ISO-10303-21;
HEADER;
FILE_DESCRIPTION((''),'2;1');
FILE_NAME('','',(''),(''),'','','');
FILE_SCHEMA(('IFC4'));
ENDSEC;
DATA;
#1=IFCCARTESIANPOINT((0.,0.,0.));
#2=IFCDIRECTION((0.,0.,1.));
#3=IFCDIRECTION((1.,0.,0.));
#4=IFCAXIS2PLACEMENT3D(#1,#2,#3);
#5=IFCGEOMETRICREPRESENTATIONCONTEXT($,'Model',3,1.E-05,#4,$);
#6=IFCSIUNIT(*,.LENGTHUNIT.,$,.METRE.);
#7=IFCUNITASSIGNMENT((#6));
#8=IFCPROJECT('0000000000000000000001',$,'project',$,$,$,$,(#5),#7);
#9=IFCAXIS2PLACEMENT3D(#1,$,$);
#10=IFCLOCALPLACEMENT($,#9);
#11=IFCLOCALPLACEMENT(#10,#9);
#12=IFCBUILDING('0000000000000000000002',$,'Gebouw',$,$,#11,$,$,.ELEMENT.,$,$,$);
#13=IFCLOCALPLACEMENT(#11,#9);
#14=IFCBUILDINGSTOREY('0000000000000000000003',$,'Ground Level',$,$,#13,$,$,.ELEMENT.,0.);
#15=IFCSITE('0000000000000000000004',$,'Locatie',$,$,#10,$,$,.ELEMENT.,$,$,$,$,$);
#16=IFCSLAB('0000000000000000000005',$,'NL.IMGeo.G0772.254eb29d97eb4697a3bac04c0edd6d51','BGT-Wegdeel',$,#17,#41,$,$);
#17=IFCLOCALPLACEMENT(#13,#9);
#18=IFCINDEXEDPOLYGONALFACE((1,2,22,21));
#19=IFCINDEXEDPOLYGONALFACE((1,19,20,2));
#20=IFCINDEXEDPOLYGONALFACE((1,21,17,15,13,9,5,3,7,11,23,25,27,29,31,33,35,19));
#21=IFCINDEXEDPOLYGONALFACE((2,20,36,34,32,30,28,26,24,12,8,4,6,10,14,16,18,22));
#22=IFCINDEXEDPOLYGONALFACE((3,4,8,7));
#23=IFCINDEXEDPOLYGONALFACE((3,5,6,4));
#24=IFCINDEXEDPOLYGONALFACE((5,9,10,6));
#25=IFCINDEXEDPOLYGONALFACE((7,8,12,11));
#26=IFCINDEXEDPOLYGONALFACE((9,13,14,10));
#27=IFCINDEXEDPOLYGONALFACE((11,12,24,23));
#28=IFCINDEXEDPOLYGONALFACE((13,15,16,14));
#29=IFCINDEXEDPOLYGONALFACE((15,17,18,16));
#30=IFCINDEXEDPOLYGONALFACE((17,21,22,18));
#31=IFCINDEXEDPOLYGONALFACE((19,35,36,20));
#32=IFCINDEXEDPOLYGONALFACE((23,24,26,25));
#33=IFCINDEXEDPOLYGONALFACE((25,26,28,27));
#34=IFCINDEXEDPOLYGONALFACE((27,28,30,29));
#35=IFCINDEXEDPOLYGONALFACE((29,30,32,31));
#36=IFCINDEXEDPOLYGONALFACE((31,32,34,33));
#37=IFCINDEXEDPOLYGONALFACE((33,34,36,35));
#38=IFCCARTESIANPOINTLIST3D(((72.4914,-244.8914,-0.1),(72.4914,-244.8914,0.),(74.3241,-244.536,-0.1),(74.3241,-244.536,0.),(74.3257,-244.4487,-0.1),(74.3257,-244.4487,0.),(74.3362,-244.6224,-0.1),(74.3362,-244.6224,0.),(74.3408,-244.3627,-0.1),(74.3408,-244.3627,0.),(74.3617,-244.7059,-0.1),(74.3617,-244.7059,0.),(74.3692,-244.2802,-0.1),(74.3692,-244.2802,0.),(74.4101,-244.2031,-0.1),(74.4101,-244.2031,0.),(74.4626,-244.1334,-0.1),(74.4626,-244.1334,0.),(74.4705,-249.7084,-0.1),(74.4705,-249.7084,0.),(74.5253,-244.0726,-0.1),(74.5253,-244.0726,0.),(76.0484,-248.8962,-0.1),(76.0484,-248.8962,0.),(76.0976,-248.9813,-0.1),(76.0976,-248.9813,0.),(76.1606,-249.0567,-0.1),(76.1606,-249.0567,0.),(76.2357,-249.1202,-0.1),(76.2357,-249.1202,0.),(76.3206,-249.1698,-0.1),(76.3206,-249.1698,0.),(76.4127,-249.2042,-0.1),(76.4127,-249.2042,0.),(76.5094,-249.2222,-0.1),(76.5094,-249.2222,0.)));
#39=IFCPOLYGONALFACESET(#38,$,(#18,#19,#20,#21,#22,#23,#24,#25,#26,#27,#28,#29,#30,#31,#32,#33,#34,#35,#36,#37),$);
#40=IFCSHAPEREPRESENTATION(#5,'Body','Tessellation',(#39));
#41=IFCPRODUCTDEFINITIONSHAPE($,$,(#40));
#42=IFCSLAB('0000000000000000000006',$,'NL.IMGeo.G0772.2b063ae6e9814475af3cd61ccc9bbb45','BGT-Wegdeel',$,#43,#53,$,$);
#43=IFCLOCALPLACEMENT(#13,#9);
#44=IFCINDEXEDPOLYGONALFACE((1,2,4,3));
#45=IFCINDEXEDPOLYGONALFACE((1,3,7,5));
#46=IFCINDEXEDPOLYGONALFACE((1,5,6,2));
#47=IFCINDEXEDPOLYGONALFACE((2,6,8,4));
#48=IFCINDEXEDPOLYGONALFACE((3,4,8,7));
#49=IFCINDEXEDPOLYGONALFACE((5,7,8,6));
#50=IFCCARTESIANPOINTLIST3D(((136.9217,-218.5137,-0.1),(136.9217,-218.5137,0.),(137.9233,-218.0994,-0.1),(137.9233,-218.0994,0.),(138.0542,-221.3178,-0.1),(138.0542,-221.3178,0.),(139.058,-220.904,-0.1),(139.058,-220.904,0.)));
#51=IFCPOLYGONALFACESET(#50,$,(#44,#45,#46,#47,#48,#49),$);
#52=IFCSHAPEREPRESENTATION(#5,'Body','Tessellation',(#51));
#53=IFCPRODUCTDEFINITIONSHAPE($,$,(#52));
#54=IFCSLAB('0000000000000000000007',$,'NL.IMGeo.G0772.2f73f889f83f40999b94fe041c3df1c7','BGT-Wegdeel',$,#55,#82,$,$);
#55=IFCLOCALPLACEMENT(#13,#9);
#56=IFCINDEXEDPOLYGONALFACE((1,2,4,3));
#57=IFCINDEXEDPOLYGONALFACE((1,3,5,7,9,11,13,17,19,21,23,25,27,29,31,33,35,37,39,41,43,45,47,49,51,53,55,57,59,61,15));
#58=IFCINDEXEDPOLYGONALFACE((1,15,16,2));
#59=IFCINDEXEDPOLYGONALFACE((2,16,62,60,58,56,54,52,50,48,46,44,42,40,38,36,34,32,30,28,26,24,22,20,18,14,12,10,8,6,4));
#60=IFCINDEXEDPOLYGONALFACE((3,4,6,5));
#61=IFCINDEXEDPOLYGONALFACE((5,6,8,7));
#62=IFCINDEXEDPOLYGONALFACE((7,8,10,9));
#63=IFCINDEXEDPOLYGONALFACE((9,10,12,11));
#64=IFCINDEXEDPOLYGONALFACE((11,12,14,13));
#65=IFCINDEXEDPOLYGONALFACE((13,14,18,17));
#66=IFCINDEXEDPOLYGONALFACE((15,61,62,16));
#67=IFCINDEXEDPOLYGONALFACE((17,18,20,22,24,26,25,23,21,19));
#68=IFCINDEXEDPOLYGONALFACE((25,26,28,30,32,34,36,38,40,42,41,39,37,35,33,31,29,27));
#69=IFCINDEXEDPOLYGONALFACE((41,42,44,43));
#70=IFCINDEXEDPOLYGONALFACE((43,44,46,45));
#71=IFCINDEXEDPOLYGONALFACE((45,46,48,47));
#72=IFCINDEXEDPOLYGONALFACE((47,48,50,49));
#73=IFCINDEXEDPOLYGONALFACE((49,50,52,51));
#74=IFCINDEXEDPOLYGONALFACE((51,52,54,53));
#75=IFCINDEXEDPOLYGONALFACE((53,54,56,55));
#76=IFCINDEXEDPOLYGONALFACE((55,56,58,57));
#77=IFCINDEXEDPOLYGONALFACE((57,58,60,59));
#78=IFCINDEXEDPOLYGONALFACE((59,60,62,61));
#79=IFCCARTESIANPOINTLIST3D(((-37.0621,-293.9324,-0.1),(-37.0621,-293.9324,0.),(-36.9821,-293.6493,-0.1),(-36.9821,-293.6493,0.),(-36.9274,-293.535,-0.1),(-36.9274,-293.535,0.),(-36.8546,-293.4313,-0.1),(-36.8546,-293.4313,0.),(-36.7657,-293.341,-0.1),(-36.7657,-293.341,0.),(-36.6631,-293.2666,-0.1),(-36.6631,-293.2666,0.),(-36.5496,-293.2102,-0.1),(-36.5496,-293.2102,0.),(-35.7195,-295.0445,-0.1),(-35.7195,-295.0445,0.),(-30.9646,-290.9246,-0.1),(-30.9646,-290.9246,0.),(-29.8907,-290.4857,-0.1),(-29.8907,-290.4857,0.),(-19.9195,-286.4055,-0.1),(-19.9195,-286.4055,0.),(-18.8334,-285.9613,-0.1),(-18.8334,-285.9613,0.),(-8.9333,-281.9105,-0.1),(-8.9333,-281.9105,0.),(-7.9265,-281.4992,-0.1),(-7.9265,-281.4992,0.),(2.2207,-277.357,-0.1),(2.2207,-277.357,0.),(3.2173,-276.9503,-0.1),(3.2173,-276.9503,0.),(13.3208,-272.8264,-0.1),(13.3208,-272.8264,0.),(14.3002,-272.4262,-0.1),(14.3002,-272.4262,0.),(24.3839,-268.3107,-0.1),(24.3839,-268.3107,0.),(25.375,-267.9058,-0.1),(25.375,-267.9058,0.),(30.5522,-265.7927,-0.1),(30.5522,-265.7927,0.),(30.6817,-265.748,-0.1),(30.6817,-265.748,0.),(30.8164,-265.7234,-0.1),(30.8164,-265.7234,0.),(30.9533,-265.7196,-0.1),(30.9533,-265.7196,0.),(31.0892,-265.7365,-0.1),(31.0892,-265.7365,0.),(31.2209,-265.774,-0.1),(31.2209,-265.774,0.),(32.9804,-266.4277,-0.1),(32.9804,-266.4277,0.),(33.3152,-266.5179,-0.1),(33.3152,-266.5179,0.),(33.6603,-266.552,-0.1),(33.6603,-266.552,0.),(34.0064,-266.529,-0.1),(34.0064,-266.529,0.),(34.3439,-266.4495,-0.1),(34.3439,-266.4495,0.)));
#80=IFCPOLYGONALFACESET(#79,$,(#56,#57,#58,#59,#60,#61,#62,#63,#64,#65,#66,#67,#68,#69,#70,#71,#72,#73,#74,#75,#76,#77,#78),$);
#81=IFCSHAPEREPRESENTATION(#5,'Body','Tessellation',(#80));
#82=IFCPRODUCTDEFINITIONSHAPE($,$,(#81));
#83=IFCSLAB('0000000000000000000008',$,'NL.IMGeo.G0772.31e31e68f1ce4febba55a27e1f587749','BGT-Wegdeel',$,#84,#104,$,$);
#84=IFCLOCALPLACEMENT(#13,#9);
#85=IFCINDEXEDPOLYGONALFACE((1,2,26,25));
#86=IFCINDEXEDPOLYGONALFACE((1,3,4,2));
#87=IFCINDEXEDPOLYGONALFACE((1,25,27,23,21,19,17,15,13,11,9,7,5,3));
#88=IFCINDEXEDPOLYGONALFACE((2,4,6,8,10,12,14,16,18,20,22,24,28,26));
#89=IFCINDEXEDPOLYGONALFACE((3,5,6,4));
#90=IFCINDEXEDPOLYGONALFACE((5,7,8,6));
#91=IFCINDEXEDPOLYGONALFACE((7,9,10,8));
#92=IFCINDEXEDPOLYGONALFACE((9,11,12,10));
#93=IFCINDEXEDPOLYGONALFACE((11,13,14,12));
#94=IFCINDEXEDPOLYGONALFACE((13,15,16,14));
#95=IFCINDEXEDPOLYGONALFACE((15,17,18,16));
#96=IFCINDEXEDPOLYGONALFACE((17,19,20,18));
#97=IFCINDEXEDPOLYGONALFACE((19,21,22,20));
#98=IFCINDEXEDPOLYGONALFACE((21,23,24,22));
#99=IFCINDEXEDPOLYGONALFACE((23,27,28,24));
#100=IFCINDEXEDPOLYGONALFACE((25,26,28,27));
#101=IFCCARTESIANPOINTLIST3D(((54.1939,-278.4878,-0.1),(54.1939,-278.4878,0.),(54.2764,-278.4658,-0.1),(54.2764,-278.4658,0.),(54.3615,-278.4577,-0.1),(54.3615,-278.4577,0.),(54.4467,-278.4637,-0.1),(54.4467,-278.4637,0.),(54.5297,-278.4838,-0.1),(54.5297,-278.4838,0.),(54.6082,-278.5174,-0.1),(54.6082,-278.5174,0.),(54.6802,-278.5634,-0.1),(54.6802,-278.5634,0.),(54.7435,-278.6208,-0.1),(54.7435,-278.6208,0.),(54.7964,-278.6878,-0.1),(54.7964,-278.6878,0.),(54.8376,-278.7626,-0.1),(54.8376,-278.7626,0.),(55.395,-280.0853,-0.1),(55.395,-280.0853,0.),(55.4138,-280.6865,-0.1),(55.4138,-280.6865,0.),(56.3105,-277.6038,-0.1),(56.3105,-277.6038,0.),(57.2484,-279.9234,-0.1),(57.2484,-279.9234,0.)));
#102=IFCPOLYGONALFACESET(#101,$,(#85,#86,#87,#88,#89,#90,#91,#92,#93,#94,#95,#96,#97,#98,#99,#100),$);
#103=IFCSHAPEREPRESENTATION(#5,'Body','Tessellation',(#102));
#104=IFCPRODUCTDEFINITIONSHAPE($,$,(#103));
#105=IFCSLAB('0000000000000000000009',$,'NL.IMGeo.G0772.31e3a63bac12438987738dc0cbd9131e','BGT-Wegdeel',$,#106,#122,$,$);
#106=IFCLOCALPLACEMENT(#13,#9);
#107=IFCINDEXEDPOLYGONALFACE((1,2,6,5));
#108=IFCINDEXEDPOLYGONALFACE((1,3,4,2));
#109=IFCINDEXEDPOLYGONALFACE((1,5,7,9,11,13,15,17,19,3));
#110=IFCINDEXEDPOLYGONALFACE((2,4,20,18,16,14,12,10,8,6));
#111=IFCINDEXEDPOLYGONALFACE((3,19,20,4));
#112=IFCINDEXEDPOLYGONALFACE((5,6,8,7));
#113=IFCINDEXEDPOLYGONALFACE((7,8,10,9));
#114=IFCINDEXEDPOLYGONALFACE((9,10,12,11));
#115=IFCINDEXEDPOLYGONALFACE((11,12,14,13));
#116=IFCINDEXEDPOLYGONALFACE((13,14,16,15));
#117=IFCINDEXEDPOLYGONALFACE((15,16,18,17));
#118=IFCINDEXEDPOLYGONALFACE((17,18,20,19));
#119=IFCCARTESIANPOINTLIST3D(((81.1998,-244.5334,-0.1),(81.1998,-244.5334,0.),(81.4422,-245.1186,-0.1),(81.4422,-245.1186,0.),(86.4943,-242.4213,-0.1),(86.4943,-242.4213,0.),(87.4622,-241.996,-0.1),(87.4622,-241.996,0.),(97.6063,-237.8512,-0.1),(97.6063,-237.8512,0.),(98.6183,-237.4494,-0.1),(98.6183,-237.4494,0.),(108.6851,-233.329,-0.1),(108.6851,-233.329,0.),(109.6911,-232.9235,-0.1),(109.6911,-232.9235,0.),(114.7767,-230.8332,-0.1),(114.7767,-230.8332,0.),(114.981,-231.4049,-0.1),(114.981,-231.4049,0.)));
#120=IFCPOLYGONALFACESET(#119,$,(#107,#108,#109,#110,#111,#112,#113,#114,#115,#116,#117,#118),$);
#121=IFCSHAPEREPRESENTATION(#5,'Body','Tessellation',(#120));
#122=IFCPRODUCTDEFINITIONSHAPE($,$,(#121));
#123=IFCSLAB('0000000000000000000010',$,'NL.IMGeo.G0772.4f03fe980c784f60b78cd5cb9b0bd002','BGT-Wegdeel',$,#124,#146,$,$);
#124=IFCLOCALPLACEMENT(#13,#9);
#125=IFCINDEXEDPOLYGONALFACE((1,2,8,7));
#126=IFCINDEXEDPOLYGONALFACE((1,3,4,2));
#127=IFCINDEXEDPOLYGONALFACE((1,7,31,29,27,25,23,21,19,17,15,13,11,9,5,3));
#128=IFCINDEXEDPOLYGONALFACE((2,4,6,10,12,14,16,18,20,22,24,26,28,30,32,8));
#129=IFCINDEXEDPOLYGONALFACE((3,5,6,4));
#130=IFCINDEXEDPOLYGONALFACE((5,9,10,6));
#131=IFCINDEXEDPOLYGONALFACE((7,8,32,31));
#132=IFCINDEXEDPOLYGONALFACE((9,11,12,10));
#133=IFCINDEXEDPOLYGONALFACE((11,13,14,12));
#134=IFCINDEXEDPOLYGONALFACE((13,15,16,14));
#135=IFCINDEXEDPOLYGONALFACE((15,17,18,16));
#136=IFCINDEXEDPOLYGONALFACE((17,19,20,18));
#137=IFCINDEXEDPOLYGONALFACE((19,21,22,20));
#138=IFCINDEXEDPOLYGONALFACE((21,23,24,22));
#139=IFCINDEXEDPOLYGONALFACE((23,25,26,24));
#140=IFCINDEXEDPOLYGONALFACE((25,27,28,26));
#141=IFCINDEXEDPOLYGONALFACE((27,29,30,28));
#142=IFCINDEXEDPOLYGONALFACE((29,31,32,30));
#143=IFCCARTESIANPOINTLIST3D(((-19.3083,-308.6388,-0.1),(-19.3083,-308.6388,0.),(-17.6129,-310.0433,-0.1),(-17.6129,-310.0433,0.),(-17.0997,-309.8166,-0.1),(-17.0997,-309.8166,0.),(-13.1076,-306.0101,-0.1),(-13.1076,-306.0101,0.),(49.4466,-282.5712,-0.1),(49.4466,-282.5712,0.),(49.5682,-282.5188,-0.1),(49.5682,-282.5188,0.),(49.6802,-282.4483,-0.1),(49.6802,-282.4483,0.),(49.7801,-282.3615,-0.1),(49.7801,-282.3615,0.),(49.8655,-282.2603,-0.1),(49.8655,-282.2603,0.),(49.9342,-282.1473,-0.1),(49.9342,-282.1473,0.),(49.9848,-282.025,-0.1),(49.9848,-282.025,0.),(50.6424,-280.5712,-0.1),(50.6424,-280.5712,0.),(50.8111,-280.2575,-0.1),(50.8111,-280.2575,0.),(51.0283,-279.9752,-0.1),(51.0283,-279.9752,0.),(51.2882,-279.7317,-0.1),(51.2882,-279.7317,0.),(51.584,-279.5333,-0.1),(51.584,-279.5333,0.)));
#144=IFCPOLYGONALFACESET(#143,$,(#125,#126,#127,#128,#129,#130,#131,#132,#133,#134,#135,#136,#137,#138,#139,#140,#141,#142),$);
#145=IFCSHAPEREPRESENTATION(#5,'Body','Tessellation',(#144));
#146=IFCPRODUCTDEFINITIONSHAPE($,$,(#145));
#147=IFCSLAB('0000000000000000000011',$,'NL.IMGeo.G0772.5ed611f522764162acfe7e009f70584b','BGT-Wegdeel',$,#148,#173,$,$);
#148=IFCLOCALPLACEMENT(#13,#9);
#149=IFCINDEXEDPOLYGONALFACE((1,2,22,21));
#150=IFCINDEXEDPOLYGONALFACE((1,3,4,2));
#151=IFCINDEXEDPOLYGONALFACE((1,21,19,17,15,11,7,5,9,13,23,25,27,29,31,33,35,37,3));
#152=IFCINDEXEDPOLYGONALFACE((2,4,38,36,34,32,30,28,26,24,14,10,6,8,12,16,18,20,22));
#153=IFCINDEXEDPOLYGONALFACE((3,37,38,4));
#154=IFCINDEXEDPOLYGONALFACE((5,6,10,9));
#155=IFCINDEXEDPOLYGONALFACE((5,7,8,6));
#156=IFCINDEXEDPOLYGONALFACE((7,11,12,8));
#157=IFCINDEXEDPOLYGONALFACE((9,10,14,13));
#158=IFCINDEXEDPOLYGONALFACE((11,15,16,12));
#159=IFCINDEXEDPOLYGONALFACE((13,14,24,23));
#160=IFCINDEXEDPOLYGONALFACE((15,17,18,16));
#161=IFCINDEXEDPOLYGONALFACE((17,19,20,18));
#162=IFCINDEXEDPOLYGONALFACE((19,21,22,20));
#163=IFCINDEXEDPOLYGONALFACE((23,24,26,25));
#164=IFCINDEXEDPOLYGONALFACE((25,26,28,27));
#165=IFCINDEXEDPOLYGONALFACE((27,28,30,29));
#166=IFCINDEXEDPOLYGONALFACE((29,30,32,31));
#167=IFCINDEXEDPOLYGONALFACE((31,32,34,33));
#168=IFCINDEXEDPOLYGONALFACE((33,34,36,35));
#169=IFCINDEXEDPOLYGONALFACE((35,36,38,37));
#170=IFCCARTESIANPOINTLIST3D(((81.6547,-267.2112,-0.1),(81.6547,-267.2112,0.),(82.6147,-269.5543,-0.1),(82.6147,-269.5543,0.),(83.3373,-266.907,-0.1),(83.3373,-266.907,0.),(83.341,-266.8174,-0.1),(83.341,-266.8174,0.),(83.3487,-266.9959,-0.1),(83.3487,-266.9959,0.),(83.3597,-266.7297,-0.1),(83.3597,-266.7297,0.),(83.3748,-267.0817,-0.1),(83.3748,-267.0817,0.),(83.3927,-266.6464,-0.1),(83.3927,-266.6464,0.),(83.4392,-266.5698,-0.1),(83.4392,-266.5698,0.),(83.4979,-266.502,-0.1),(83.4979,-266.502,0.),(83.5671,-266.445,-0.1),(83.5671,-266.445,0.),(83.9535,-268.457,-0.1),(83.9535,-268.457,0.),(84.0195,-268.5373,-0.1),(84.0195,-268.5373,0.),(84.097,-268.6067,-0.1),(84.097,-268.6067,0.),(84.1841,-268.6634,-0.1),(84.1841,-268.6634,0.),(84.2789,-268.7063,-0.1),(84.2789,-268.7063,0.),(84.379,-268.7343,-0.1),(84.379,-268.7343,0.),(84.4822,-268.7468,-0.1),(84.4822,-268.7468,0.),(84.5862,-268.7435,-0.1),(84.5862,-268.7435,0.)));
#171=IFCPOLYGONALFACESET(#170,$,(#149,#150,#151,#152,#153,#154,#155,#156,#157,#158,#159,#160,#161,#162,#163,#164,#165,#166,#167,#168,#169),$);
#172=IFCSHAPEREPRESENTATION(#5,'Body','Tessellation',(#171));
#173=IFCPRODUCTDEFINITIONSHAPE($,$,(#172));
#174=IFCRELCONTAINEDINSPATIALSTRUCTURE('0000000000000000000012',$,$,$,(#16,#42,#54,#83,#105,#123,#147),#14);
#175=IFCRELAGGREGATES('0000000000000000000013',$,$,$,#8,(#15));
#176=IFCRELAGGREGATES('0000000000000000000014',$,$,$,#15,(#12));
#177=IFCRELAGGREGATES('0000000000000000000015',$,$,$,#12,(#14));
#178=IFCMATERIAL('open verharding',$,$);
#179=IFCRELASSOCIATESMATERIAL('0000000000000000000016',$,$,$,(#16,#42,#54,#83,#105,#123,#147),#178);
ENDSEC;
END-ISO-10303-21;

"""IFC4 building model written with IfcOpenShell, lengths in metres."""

from ifc_helpers import new_model, si_unit, frame, origin, origin_with_axes, place, context, project, spatial, polyline, outline, extrude, material, element, save


model = new_model("IFC4")

# Units and contexts
model_context = context("Model", 3, precision=1e-05, world=origin_with_axes())
ifc_project = project(units=[si_unit("LENGTHUNIT", "METRE")], contexts=[model_context])

# Site, building, storey
site_placement = place(None, origin())
site = spatial("IfcSite", under=ifc_project, at=site_placement, Name="Locatie", CompositionType="ELEMENT")
building_placement = place(site_placement, origin())
building = spatial("IfcBuilding", under=site, at=building_placement, Name="Gebouw", CompositionType="ELEMENT")
storey_placement = place(building_placement, origin())
storey = spatial("IfcBuildingStorey", under=building, at=storey_placement, Name="Ground Level", CompositionType="ELEMENT", Elevation=0.0)

# Slabs
ifc_material = material(Name="open verharding")
slab_1_placement = place(storey_placement, origin())
element("IfcSlab", 1, at=slab_1_placement, inside=storey, material=ifc_material, Name="NL.IMGeo.G0772.254eb29d97eb4697a3bac04c0edd6d51", Description="BGT-Wegdeel", context=model_context, shape_type="SweptSolid", body=[
    extrude(outline(polyline([(74.4705, -249.7084), (72.4914, -244.8914), (74.5253, -244.0726), (74.4626, -244.1334), (74.4101, -244.2031), (74.3692, -244.2802), (74.3408, -244.3627), (74.3257, -244.4487), (74.3241, -244.536), (74.3362, -244.6224), (74.3617, -244.7059), (76.0484, -248.8962), (76.0976, -248.9813), (76.1606, -249.0567), (76.2357, -249.1202), (76.3206, -249.1698), (76.4127, -249.2042), (76.5094, -249.2222), (74.4705, -249.7084)])), frame((0.0, 0.0, -0.1), z_axis=(0.0, 0.0, 1.0), x_axis=(1.0, 0.0, 0.0)), (0.0, 0.0, 1.0), 0.1),
])
slab_2_placement = place(storey_placement, origin())
element("IfcSlab", 2, at=slab_2_placement, inside=storey, material=ifc_material, Name="NL.IMGeo.G0772.2b063ae6e9814475af3cd61ccc9bbb45", Description="BGT-Wegdeel", context=model_context, shape_type="SweptSolid", body=[
    extrude(outline(polyline([(137.9233, -218.0994), (139.058, -220.904), (138.0542, -221.3178), (136.9217, -218.5137), (137.9233, -218.0994)])), frame((0.0, 0.0, -0.1), z_axis=(0.0, 0.0, 1.0), x_axis=(1.0, 0.0, 0.0)), (0.0, 0.0, 1.0), 0.1),
])
slab_3_placement = place(storey_placement, origin())
element("IfcSlab", 3, at=slab_3_placement, inside=storey, material=ifc_material, Name="NL.IMGeo.G0772.2f73f889f83f40999b94fe041c3df1c7", Description="BGT-Wegdeel", context=model_context, shape_type="SweptSolid", body=[
    extrude(outline(polyline([(-36.9821, -293.6493), (-36.9274, -293.535), (-36.8546, -293.4313), (-36.7657, -293.341), (-36.6631, -293.2666), (-36.5496, -293.2102), (-30.9646, -290.9246), (-29.8907, -290.4857), (-19.9195, -286.4055), (-18.8334, -285.9613), (-8.9333, -281.9105), (-7.9265, -281.4992), (2.2207, -277.357), (3.2173, -276.9503), (13.3208, -272.8264), (14.3002, -272.4262), (24.3839, -268.3107), (25.375, -267.9058), (30.5522, -265.7927), (30.6817, -265.748), (30.8164, -265.7234), (30.9533, -265.7196), (31.0892, -265.7365), (31.2209, -265.774), (32.9804, -266.4277), (33.3152, -266.5179), (33.6603, -266.552), (34.0064, -266.529), (34.3439, -266.4495), (-35.7195, -295.0445), (-37.0621, -293.9324), (-36.9821, -293.6493)])), frame((0.0, 0.0, -0.1), z_axis=(0.0, 0.0, 1.0), x_axis=(1.0, 0.0, 0.0)), (0.0, 0.0, 1.0), 0.1),
])
slab_4_placement = place(storey_placement, origin())
element("IfcSlab", 4, at=slab_4_placement, inside=storey, material=ifc_material, Name="NL.IMGeo.G0772.31e31e68f1ce4febba55a27e1f587749", Description="BGT-Wegdeel", context=model_context, shape_type="SweptSolid", body=[
    extrude(outline(polyline([(54.7964, -278.6878), (54.7435, -278.6208), (54.6802, -278.5634), (54.6082, -278.5174), (54.5297, -278.4838), (54.4467, -278.4637), (54.3615, -278.4577), (54.2764, -278.4658), (54.1939, -278.4878), (56.3105, -277.6038), (57.2484, -279.9234), (55.4138, -280.6865), (55.395, -280.0853), (54.8376, -278.7626), (54.7964, -278.6878)])), frame((0.0, 0.0, -0.1), z_axis=(0.0, 0.0, 1.0), x_axis=(1.0, 0.0, 0.0)), (0.0, 0.0, 1.0), 0.1),
])
slab_5_placement = place(storey_placement, origin())
element("IfcSlab", 5, at=slab_5_placement, inside=storey, material=ifc_material, Name="NL.IMGeo.G0772.31e3a63bac12438987738dc0cbd9131e", Description="BGT-Wegdeel", context=model_context, shape_type="SweptSolid", body=[
    extrude(outline(polyline([(98.6183, -237.4494), (108.6851, -233.329), (109.6911, -232.9235), (114.7767, -230.8332), (114.981, -231.4049), (81.4422, -245.1186), (81.1998, -244.5334), (86.4943, -242.4213), (87.4622, -241.996), (97.6063, -237.8512), (98.6183, -237.4494)])), frame((0.0, 0.0, -0.1), z_axis=(0.0, 0.0, 1.0), x_axis=(1.0, 0.0, 0.0)), (0.0, 0.0, 1.0), 0.1),
])
slab_6_placement = place(storey_placement, origin())
element("IfcSlab", 6, at=slab_6_placement, inside=storey, material=ifc_material, Name="NL.IMGeo.G0772.4f03fe980c784f60b78cd5cb9b0bd002", Description="BGT-Wegdeel", context=model_context, shape_type="SweptSolid", body=[
    extrude(outline(polyline([(-13.1076, -306.0101), (51.584, -279.5333), (51.2882, -279.7317), (51.0283, -279.9752), (50.8111, -280.2575), (50.6424, -280.5712), (49.9848, -282.025), (49.9342, -282.1473), (49.8655, -282.2603), (49.7801, -282.3615), (49.6802, -282.4483), (49.5682, -282.5188), (49.4466, -282.5712), (-17.0997, -309.8166), (-17.6129, -310.0433), (-19.3083, -308.6388), (-13.1076, -306.0101)])), frame((0.0, 0.0, -0.1), z_axis=(0.0, 0.0, 1.0), x_axis=(1.0, 0.0, 0.0)), (0.0, 0.0, 1.0), 0.1),
])
slab_7_placement = place(storey_placement, origin())
element("IfcSlab", 7, at=slab_7_placement, inside=storey, material=ifc_material, Name="NL.IMGeo.G0772.5ed611f522764162acfe7e009f70584b", Description="BGT-Wegdeel", context=model_context, shape_type="SweptSolid", body=[
    extrude(outline(polyline([(83.4979, -266.502), (83.4392, -266.5698), (83.3927, -266.6464), (83.3597, -266.7297), (83.341, -266.8174), (83.3373, -266.907), (83.3487, -266.9959), (83.3748, -267.0817), (83.9535, -268.457), (84.0195, -268.5373), (84.097, -268.6067), (84.1841, -268.6634), (84.2789, -268.7063), (84.379, -268.7343), (84.4822, -268.7468), (84.5862, -268.7435), (82.6147, -269.5543), (81.6547, -267.2112), (83.5671, -266.445), (83.4979, -266.502)])), frame((0.0, 0.0, -0.1), z_axis=(0.0, 0.0, 1.0), x_axis=(1.0, 0.0, 0.0)), (0.0, 0.0, 1.0), 0.1),
])

save(model, "model.ifc")
